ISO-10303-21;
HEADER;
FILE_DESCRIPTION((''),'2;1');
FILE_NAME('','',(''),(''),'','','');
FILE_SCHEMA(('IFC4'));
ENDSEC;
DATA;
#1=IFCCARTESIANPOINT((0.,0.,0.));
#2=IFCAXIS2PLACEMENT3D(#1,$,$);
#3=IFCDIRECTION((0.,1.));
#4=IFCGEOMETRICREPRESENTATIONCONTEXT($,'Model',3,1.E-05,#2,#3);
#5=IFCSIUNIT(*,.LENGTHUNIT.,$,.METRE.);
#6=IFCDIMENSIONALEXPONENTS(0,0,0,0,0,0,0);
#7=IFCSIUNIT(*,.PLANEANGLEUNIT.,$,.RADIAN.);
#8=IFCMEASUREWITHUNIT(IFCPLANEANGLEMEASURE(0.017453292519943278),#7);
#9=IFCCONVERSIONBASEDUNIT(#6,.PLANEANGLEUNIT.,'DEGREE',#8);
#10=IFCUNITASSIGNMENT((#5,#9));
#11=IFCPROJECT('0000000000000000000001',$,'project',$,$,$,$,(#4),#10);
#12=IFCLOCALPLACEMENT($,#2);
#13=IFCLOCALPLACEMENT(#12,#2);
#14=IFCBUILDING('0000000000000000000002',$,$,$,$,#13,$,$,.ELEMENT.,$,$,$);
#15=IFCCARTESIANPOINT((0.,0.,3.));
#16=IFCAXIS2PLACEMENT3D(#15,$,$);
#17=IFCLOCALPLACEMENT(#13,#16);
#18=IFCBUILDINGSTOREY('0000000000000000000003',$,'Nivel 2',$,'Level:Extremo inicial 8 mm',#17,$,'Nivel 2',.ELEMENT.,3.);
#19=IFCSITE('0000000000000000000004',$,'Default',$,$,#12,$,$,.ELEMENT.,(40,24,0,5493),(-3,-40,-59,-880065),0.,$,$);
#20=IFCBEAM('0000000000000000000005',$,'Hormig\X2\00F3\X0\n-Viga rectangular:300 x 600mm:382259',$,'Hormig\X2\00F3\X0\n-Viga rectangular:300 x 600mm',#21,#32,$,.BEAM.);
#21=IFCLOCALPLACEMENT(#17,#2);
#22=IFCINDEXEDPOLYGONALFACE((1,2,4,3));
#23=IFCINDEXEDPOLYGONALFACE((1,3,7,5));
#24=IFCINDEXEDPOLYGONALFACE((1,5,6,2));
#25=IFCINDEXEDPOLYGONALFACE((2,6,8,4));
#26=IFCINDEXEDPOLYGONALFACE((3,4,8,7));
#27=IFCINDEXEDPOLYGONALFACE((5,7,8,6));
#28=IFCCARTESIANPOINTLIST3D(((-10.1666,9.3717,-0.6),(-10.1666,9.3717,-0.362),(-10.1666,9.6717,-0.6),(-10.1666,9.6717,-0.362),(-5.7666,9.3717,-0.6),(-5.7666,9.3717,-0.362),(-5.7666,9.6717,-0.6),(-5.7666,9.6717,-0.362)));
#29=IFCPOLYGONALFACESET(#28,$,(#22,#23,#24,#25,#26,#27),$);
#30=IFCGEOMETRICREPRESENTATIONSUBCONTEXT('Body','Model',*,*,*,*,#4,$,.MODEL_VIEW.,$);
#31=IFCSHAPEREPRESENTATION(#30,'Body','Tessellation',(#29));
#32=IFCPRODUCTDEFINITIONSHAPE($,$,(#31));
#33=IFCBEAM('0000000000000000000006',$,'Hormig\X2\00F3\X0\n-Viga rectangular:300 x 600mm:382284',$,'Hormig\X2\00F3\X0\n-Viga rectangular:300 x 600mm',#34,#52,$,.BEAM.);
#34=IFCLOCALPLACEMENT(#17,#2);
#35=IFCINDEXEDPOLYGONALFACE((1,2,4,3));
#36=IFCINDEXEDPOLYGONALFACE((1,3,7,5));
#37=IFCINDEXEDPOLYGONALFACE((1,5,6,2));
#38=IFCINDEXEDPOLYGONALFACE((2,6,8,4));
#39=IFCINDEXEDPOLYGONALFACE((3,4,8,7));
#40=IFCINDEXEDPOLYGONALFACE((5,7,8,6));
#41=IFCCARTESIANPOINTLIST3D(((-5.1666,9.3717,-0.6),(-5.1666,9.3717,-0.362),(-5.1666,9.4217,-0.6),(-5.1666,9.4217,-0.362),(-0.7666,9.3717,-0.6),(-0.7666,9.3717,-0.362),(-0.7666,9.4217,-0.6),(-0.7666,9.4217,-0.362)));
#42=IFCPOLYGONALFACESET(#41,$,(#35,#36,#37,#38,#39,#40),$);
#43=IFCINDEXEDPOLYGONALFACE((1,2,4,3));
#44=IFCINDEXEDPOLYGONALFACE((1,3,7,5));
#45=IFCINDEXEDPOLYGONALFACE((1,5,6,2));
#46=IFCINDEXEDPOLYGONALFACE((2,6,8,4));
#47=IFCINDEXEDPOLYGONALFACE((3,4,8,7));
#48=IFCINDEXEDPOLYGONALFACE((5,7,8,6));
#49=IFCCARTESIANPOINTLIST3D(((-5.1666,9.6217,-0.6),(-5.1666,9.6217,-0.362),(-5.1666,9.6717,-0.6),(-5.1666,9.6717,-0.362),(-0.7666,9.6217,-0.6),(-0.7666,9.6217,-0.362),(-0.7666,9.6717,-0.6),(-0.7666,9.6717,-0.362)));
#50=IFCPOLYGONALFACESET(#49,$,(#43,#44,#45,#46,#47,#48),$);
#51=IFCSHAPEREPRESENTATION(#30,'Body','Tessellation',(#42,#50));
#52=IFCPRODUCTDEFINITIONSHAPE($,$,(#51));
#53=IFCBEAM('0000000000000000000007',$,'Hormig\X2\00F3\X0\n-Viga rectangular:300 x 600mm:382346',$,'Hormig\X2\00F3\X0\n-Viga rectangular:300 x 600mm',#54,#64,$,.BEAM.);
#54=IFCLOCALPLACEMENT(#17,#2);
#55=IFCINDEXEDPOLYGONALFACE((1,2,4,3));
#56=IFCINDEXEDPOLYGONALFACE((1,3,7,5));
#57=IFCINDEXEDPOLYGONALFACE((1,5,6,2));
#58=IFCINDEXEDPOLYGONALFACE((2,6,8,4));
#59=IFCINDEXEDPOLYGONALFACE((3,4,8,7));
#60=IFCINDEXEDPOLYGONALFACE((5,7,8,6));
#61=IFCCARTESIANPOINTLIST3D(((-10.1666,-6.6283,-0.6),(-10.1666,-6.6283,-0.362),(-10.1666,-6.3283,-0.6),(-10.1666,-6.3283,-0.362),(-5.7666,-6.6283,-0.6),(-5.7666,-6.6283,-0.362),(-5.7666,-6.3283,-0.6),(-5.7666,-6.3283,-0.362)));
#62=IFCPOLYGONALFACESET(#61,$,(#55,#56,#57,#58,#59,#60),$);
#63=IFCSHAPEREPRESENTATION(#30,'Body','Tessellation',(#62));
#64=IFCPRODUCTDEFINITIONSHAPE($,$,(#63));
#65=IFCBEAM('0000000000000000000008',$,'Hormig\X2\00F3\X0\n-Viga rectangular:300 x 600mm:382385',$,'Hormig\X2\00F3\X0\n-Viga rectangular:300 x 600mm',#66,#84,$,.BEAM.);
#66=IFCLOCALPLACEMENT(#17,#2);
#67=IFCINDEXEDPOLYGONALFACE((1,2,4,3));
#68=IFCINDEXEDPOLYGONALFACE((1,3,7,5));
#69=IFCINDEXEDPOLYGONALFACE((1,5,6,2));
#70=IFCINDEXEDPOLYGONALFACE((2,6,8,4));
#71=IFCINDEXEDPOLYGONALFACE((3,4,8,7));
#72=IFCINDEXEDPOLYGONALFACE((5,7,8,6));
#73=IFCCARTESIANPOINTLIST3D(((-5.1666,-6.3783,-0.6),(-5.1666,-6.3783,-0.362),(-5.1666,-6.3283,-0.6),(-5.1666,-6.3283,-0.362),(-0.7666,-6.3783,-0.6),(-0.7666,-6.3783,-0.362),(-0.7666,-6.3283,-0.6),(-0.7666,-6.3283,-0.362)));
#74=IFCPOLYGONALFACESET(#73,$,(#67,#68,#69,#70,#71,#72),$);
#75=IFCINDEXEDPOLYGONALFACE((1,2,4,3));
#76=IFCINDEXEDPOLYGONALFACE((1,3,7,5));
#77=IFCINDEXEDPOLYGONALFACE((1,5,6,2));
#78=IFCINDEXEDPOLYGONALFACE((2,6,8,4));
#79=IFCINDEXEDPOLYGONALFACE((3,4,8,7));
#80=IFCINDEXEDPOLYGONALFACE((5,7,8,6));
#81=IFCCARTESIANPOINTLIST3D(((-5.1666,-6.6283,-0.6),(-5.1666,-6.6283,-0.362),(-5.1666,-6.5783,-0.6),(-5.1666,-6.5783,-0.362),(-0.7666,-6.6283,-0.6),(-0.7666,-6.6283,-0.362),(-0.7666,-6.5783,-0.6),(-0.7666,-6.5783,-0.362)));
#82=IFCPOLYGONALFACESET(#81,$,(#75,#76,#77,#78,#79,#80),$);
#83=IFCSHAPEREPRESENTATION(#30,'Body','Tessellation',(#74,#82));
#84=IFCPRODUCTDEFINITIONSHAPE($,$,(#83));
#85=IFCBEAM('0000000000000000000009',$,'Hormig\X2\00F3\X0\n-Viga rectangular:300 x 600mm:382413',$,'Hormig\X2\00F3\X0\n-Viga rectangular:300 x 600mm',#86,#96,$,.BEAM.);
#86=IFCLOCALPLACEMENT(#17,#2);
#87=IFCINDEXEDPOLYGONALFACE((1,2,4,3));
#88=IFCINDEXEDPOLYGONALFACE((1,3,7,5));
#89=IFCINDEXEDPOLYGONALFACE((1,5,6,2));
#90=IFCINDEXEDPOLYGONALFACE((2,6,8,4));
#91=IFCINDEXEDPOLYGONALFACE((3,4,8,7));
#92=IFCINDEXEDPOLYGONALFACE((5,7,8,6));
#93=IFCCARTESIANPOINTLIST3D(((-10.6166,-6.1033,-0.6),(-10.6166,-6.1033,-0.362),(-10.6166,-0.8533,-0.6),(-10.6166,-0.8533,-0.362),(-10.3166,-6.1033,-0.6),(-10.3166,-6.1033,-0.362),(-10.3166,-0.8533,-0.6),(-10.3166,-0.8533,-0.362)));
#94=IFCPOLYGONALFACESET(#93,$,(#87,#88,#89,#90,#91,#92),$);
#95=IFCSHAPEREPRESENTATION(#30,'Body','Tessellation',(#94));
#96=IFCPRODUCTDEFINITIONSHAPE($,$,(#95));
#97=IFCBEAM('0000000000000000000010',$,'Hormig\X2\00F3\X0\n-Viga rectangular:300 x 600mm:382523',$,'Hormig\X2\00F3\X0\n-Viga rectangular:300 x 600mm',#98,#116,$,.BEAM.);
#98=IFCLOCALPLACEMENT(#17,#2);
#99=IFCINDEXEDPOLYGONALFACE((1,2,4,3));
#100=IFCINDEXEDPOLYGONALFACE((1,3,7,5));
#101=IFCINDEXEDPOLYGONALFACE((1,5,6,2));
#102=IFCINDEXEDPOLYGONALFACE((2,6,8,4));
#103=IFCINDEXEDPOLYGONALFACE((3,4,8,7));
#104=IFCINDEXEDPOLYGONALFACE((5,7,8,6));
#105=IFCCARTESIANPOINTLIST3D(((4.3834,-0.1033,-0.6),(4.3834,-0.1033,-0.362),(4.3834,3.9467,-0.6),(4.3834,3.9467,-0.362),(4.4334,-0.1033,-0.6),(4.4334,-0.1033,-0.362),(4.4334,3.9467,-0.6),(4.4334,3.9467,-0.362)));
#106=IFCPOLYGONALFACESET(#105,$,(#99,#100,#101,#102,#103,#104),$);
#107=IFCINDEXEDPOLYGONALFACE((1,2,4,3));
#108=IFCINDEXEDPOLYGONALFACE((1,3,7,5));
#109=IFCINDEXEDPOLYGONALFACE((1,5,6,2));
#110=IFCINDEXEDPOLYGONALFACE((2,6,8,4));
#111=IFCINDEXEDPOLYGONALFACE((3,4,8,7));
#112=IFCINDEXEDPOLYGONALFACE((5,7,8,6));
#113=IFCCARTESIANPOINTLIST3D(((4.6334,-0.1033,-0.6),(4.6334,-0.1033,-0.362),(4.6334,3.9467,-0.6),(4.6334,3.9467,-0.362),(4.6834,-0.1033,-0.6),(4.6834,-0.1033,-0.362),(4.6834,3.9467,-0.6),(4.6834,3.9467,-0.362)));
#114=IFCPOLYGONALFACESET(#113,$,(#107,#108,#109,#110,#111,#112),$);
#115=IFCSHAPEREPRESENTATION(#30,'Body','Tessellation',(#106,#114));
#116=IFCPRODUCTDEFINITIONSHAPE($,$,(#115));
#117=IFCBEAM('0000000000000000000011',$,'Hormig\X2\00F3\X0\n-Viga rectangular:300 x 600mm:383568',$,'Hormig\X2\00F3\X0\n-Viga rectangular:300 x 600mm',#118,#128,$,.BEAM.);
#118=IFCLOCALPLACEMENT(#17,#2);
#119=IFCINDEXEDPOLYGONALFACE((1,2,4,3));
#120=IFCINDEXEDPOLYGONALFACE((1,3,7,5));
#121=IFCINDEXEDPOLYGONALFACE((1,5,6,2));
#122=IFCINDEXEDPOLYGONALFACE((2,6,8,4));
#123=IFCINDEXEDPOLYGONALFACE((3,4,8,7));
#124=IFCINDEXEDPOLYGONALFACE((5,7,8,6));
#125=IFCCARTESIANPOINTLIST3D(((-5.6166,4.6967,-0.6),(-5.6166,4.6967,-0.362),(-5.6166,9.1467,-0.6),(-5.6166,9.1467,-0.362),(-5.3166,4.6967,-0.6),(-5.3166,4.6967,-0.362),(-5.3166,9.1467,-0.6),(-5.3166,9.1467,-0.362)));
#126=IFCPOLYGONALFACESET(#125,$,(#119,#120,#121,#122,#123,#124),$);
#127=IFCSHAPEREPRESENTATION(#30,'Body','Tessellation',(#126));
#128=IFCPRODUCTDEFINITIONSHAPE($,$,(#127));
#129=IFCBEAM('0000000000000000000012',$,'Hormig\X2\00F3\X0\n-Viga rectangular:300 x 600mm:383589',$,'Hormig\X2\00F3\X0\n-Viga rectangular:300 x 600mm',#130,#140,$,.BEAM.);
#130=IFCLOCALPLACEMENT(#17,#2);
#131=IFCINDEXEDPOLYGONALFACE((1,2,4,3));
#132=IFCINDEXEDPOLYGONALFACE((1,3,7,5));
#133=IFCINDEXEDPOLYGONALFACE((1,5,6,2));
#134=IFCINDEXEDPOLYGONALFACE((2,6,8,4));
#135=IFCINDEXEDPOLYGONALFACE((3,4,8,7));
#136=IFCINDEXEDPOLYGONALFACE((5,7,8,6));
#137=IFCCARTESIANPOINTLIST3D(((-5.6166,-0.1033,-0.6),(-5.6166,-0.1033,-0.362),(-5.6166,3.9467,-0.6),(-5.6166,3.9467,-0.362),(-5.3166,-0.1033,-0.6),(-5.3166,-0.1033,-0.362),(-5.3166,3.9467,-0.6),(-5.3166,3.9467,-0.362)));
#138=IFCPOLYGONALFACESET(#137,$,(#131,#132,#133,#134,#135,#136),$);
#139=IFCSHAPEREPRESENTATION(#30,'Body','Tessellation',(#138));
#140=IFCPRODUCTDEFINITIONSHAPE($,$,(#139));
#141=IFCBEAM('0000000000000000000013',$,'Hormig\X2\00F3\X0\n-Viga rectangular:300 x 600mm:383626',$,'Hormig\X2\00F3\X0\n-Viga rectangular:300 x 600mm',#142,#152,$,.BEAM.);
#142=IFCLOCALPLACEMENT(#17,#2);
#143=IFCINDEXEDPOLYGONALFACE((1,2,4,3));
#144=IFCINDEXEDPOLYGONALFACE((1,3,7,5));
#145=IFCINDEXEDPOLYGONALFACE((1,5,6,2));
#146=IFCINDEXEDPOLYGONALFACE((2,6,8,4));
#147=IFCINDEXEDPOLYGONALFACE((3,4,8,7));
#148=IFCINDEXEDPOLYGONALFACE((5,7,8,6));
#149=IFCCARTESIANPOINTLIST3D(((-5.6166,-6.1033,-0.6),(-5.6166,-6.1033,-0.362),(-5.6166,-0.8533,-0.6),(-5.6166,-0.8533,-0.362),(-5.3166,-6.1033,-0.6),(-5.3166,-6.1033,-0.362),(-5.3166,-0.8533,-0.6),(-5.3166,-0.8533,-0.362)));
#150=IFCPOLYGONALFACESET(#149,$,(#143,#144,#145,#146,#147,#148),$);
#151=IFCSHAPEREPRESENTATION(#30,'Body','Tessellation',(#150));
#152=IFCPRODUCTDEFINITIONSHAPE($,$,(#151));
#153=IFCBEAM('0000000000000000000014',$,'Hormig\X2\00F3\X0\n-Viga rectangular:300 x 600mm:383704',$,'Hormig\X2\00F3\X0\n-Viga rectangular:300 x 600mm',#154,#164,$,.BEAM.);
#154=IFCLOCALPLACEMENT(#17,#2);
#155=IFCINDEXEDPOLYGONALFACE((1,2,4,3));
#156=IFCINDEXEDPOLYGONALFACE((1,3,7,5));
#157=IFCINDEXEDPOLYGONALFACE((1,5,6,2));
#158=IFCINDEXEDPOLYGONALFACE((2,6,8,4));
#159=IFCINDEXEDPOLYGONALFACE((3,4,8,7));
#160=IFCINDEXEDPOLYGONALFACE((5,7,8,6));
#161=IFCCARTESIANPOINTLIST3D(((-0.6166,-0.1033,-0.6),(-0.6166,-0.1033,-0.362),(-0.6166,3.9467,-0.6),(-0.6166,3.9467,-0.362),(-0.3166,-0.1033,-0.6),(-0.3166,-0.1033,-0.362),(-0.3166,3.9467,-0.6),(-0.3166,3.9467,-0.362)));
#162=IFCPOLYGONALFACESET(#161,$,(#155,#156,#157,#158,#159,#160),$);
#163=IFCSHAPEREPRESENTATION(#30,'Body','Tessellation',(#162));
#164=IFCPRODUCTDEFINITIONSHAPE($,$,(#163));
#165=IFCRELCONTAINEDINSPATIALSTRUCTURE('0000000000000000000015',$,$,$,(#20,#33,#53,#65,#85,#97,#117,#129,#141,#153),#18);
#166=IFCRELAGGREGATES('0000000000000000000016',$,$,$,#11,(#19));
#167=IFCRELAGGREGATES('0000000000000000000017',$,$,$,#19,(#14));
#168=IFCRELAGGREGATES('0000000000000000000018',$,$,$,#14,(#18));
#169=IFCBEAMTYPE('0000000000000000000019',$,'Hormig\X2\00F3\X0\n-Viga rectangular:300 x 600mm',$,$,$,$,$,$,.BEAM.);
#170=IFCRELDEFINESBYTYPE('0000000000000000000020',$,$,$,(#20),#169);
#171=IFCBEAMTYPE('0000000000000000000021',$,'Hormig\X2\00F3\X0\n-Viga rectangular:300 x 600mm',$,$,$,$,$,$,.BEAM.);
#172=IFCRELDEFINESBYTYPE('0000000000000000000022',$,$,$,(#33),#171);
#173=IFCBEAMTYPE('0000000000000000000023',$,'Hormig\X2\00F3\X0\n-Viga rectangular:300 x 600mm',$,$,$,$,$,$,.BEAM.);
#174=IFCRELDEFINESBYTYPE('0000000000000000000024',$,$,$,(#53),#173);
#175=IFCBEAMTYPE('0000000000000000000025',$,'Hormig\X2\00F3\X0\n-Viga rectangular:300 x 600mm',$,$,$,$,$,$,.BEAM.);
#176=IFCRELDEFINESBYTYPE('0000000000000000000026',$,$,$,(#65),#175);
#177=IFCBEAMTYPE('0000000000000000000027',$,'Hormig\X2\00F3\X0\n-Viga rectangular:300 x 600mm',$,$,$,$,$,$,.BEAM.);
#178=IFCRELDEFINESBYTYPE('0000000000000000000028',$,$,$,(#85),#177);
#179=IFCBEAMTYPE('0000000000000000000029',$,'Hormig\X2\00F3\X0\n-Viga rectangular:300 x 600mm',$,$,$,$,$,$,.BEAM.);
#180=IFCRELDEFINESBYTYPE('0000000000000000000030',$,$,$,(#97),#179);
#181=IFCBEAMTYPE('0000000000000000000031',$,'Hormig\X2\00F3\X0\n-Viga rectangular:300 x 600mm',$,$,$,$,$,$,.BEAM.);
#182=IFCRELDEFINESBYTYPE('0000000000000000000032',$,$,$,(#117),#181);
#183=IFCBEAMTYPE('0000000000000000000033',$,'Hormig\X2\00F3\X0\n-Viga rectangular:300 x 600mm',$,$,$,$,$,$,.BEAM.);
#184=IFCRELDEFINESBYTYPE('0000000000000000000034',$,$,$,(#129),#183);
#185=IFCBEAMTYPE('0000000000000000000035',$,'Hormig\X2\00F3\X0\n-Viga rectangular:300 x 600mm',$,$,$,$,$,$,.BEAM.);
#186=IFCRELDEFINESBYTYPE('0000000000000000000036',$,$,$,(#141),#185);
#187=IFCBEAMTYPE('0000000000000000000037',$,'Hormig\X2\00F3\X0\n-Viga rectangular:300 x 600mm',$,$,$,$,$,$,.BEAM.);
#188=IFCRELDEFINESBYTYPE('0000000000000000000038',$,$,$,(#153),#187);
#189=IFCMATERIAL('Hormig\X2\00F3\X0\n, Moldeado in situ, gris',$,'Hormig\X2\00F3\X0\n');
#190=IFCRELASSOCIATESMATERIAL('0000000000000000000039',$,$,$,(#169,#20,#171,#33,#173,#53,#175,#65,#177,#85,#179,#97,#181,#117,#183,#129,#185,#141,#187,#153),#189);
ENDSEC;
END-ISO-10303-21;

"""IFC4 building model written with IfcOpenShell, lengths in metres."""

from ifc_helpers import new_model, entity, si_unit, converted_unit, direction, frame, origin, place, context, subcontext, project, spatial, indexed_curve, outline, extrude, source, transform, mapped, material, type_object, type_shapes, element, save


model = new_model("IFC4")

# Units and contexts
model_context = context("Model", 3, precision=1e-05, world=origin(), true_north=direction((0.0, 1.0)))
body_context = subcontext(model_context, "Body", "Model", "MODEL_VIEW")
ifc_project = project(units=[si_unit("LENGTHUNIT", "METRE"), converted_unit("PLANEANGLEUNIT", "DEGREE", entity("IfcPlaneAngleMeasure", 0.017453292519943278), si_unit("PLANEANGLEUNIT", "RADIAN"), dimensions=[0, 0, 0, 0, 0, 0, 0])], contexts=[model_context])

# Site, building, storey
site_placement = place(None, origin())
site = spatial("IfcSite", under=ifc_project, at=site_placement, Name="Default", CompositionType="ELEMENT", RefLatitude=(40, 24, 0, 5493), RefLongitude=(-3, -40, -59, -880065), RefElevation=0.0)
building_placement = place(site_placement, origin())
building = spatial("IfcBuilding", under=site, at=building_placement, CompositionType="ELEMENT")
storey_placement = place(building_placement, frame((0.0, 0.0, 3.0)))
storey = spatial("IfcBuildingStorey", under=building, at=storey_placement, Name="Nivel 2", ObjectType="Level:Extremo inicial 8 mm", LongName="Nivel 2", CompositionType="ELEMENT", Elevation=3.0)

# Beams
ifc_material_1 = material(Name="Hormigón, Moldeado in situ, gris", Category="Hormigón")
beam_type_1 = type_object("IfcBeamType", Name="Hormigón-Viga rectangular:300 x 600mm", PredefinedType="BEAM", material=ifc_material_1)
shared_shape_1 = source(origin(), body_context, "Body", "SweptSolid", [
    extrude(outline(indexed_curve([(-0.119, -0.15), (0.119, -0.15), (0.119, 0.15), (-0.119, 0.15), (-0.119, -0.15)], self_intersect=False)), frame((-5.7666, 9.5217, 2.519), z_axis=(-1.0, 0.0, 0.0), x_axis=(0.0, 0.0, -1.0)), (0.0, 0.0, 1.0), 4.4),
])
type_shapes(beam_type_1, [shared_shape_1])
beam_1_placement = place(storey_placement, frame((0.0, 0.0, -3.0)))
element("IfcBeam", 1, at=beam_1_placement, inside=storey, type_object=beam_type_1, material=ifc_material_1, Name="Hormigón-Viga rectangular:300 x 600mm:382259", ObjectType="Hormigón-Viga rectangular:300 x 600mm", PredefinedType="BEAM", context=body_context, shape_type="MappedRepresentation", body=[
    mapped(shared_shape_1, transform((0.0, 0.0, 0.0), scale=1.0)),
])
beam_type_2 = type_object("IfcBeamType", Name="Hormigón-Viga rectangular:300 x 600mm", PredefinedType="BEAM", material=ifc_material_1)
shared_shape_2 = source(origin(), body_context, "Body", "SweptSolid", [
    extrude(outline(indexed_curve([(-0.119, -0.025), (0.119, -0.025), (0.119, 0.025), (-0.119, 0.025), (-0.119, -0.025)], self_intersect=False)), frame((-5.1666, 9.3967, 2.519), z_axis=(1.0, 0.0, 0.0), x_axis=(0.0, 0.0, -1.0)), (0.0, 0.0, 1.0), 4.4),
    extrude(outline(indexed_curve([(-0.119, -0.025), (0.119, -0.025), (0.119, 0.025), (-0.119, 0.025), (-0.119, -0.025)], self_intersect=False)), frame((-5.1666, 9.6467, 2.519), z_axis=(1.0, 0.0, 0.0), x_axis=(0.0, 0.0, -1.0)), (0.0, 0.0, 1.0), 4.4),
])
type_shapes(beam_type_2, [shared_shape_2])
beam_2_placement = place(storey_placement, frame((0.0, 0.0, -3.0)))
element("IfcBeam", 2, at=beam_2_placement, inside=storey, type_object=beam_type_2, material=ifc_material_1, Name="Hormigón-Viga rectangular:300 x 600mm:382284", ObjectType="Hormigón-Viga rectangular:300 x 600mm", PredefinedType="BEAM", context=body_context, shape_type="MappedRepresentation", body=[
    mapped(shared_shape_2, transform((0.0, 0.0, 0.0), scale=1.0)),
])
beam_type_3 = type_object("IfcBeamType", Name="Hormigón-Viga rectangular:300 x 600mm", PredefinedType="BEAM", material=ifc_material_1)
shared_shape_3 = source(origin(), body_context, "Body", "SweptSolid", [
    extrude(outline(indexed_curve([(-0.119, -0.15), (0.119, -0.15), (0.119, 0.15), (-0.119, 0.15), (-0.119, -0.15)], self_intersect=False)), frame((-10.1666, -6.4783, 2.519), z_axis=(1.0, 0.0, 0.0), x_axis=(0.0, 0.0, -1.0)), (0.0, 0.0, 1.0), 4.4),
])
type_shapes(beam_type_3, [shared_shape_3])
beam_3_placement = place(storey_placement, frame((0.0, 0.0, -3.0)))
element("IfcBeam", 3, at=beam_3_placement, inside=storey, type_object=beam_type_3, material=ifc_material_1, Name="Hormigón-Viga rectangular:300 x 600mm:382346", ObjectType="Hormigón-Viga rectangular:300 x 600mm", PredefinedType="BEAM", context=body_context, shape_type="MappedRepresentation", body=[
    mapped(shared_shape_3, transform((0.0, 0.0, 0.0), scale=1.0)),
])
beam_type_4 = type_object("IfcBeamType", Name="Hormigón-Viga rectangular:300 x 600mm", PredefinedType="BEAM", material=ifc_material_1)
shared_shape_4 = source(origin(), body_context, "Body", "SweptSolid", [
    extrude(outline(indexed_curve([(-0.119, -0.025), (0.119, -0.025), (0.119, 0.025), (-0.119, 0.025), (-0.119, -0.025)], self_intersect=False)), frame((-0.7666, -6.3533, 2.519), z_axis=(-1.0, 0.0, 0.0), x_axis=(0.0, 0.0, -1.0)), (0.0, 0.0, 1.0), 4.4),
    extrude(outline(indexed_curve([(-0.119, -0.025), (0.119, -0.025), (0.119, 0.025), (-0.119, 0.025), (-0.119, -0.025)], self_intersect=False)), frame((-0.7666, -6.6033, 2.519), z_axis=(-1.0, 0.0, 0.0), x_axis=(0.0, 0.0, -1.0)), (0.0, 0.0, 1.0), 4.4),
])
type_shapes(beam_type_4, [shared_shape_4])
beam_4_placement = place(storey_placement, frame((0.0, 0.0, -3.0)))
element("IfcBeam", 4, at=beam_4_placement, inside=storey, type_object=beam_type_4, material=ifc_material_1, Name="Hormigón-Viga rectangular:300 x 600mm:382385", ObjectType="Hormigón-Viga rectangular:300 x 600mm", PredefinedType="BEAM", context=body_context, shape_type="MappedRepresentation", body=[
    mapped(shared_shape_4, transform((0.0, 0.0, 0.0), scale=1.0)),
])
beam_type_5 = type_object("IfcBeamType", Name="Hormigón-Viga rectangular:300 x 600mm", PredefinedType="BEAM", material=ifc_material_1)
shared_shape_5 = source(origin(), body_context, "Body", "SweptSolid", [
    extrude(outline(indexed_curve([(-0.15, -0.119), (0.15, -0.119), (0.15, 0.119), (-0.15, 0.119), (-0.15, -0.119)], self_intersect=False)), frame((-10.4666, -6.1033, 2.519), z_axis=(0.0, 1.0, 0.0), x_axis=(-1.0, 0.0, 0.0)), (0.0, 0.0, 1.0), 5.25),
])
type_shapes(beam_type_5, [shared_shape_5])
beam_5_placement = place(storey_placement, frame((0.0, 0.0, -3.0)))
element("IfcBeam", 5, at=beam_5_placement, inside=storey, type_object=beam_type_5, material=ifc_material_1, Name="Hormigón-Viga rectangular:300 x 600mm:382413", ObjectType="Hormigón-Viga rectangular:300 x 600mm", PredefinedType="BEAM", context=body_context, shape_type="MappedRepresentation", body=[
    mapped(shared_shape_5, transform((0.0, 0.0, 0.0), scale=1.0)),
])
beam_type_6 = type_object("IfcBeamType", Name="Hormigón-Viga rectangular:300 x 600mm", PredefinedType="BEAM", material=ifc_material_1)
shared_shape_6 = source(origin(), body_context, "Body", "SweptSolid", [
    extrude(outline(indexed_curve([(-0.025, -0.119), (0.025, -0.119), (0.025, 0.119), (-0.025, 0.119), (-0.025, -0.119)], self_intersect=False)), frame((4.4084, 3.9467, 2.519), z_axis=(0.0, -1.0, 0.0), x_axis=(-1.0, 0.0, 0.0)), (0.0, 0.0, 1.0), 4.05),
    extrude(outline(indexed_curve([(-0.025, -0.119), (0.025, -0.119), (0.025, 0.119), (-0.025, 0.119), (-0.025, -0.119)], self_intersect=False)), frame((4.6584, 3.9467, 2.519), z_axis=(0.0, -1.0, 0.0), x_axis=(-1.0, 0.0, 0.0)), (0.0, 0.0, 1.0), 4.05),
])
type_shapes(beam_type_6, [shared_shape_6])
beam_6_placement = place(storey_placement, frame((0.0, 0.0, -3.0)))
element("IfcBeam", 6, at=beam_6_placement, inside=storey, type_object=beam_type_6, material=ifc_material_1, Name="Hormigón-Viga rectangular:300 x 600mm:382523", ObjectType="Hormigón-Viga rectangular:300 x 600mm", PredefinedType="BEAM", context=body_context, shape_type="MappedRepresentation", body=[
    mapped(shared_shape_6, transform((0.0, 0.0, 0.0), scale=1.0)),
])
beam_type_7 = type_object("IfcBeamType", Name="Hormigón-Viga rectangular:300 x 600mm", PredefinedType="BEAM", material=ifc_material_1)
shared_shape_7 = source(origin(), body_context, "Body", "SweptSolid", [
    extrude(outline(indexed_curve([(-0.15, -0.119), (0.15, -0.119), (0.15, 0.119), (-0.15, 0.119), (-0.15, -0.119)], self_intersect=False)), frame((-5.4666, 9.1467, 2.519), z_axis=(0.0, -1.0, 0.0), x_axis=(-1.0, 0.0, 0.0)), (0.0, 0.0, 1.0), 4.45),
])
type_shapes(beam_type_7, [shared_shape_7])
beam_7_placement = place(storey_placement, frame((0.0, 0.0, -3.0)))
element("IfcBeam", 7, at=beam_7_placement, inside=storey, type_object=beam_type_7, material=ifc_material_1, Name="Hormigón-Viga rectangular:300 x 600mm:383568", ObjectType="Hormigón-Viga rectangular:300 x 600mm", PredefinedType="BEAM", context=body_context, shape_type="MappedRepresentation", body=[
    mapped(shared_shape_7, transform((0.0, 0.0, 0.0), scale=1.0)),
])
beam_type_8 = type_object("IfcBeamType", Name="Hormigón-Viga rectangular:300 x 600mm", PredefinedType="BEAM", material=ifc_material_1)
shared_shape_8 = source(origin(), body_context, "Body", "SweptSolid", [
    extrude(outline(indexed_curve([(-0.15, -0.119), (0.15, -0.119), (0.15, 0.119), (-0.15, 0.119), (-0.15, -0.119)], self_intersect=False)), frame((-5.4666, 3.9467, 2.519), z_axis=(0.0, -1.0, 0.0), x_axis=(-1.0, 0.0, 0.0)), (0.0, 0.0, 1.0), 4.05),
])
type_shapes(beam_type_8, [shared_shape_8])
beam_8_placement = place(storey_placement, frame((0.0, 0.0, -3.0)))
element("IfcBeam", 8, at=beam_8_placement, inside=storey, type_object=beam_type_8, material=ifc_material_1, Name="Hormigón-Viga rectangular:300 x 600mm:383589", ObjectType="Hormigón-Viga rectangular:300 x 600mm", PredefinedType="BEAM", context=body_context, shape_type="MappedRepresentation", body=[
    mapped(shared_shape_8, transform((0.0, 0.0, 0.0), scale=1.0)),
])
beam_type_9 = type_object("IfcBeamType", Name="Hormigón-Viga rectangular:300 x 600mm", PredefinedType="BEAM", material=ifc_material_1)
shared_shape_9 = source(origin(), body_context, "Body", "SweptSolid", [
    extrude(outline(indexed_curve([(-0.15, -0.119), (0.15, -0.119), (0.15, 0.119), (-0.15, 0.119), (-0.15, -0.119)], self_intersect=False)), frame((-5.4666, -6.1033, 2.519), z_axis=(0.0, 1.0, 0.0), x_axis=(-1.0, 0.0, 0.0)), (0.0, 0.0, 1.0), 5.25),
])
type_shapes(beam_type_9, [shared_shape_9])
beam_9_placement = place(storey_placement, frame((0.0, 0.0, -3.0)))
element("IfcBeam", 9, at=beam_9_placement, inside=storey, type_object=beam_type_9, material=ifc_material_1, Name="Hormigón-Viga rectangular:300 x 600mm:383626", ObjectType="Hormigón-Viga rectangular:300 x 600mm", PredefinedType="BEAM", context=body_context, shape_type="MappedRepresentation", body=[
    mapped(shared_shape_9, transform((0.0, 0.0, 0.0), scale=1.0)),
])
beam_type_10 = type_object("IfcBeamType", Name="Hormigón-Viga rectangular:300 x 600mm", PredefinedType="BEAM", material=ifc_material_1)
shared_shape_10 = source(origin(), body_context, "Body", "SweptSolid", [
    extrude(outline(indexed_curve([(-0.15, -0.119), (0.15, -0.119), (0.15, 0.119), (-0.15, 0.119), (-0.15, -0.119)], self_intersect=False)), frame((-0.4666, -0.1033, 2.519), z_axis=(0.0, 1.0, 0.0), x_axis=(-1.0, 0.0, 0.0)), (0.0, 0.0, 1.0), 4.05),
])
type_shapes(beam_type_10, [shared_shape_10])
beam_10_placement = place(storey_placement, frame((0.0, 0.0, -3.0)))
element("IfcBeam", 10, at=beam_10_placement, inside=storey, type_object=beam_type_10, material=ifc_material_1, Name="Hormigón-Viga rectangular:300 x 600mm:383704", ObjectType="Hormigón-Viga rectangular:300 x 600mm", PredefinedType="BEAM", context=body_context, shape_type="MappedRepresentation", body=[
    mapped(shared_shape_10, transform((0.0, 0.0, 0.0), scale=1.0)),
])

save(model, "model.ifc")
